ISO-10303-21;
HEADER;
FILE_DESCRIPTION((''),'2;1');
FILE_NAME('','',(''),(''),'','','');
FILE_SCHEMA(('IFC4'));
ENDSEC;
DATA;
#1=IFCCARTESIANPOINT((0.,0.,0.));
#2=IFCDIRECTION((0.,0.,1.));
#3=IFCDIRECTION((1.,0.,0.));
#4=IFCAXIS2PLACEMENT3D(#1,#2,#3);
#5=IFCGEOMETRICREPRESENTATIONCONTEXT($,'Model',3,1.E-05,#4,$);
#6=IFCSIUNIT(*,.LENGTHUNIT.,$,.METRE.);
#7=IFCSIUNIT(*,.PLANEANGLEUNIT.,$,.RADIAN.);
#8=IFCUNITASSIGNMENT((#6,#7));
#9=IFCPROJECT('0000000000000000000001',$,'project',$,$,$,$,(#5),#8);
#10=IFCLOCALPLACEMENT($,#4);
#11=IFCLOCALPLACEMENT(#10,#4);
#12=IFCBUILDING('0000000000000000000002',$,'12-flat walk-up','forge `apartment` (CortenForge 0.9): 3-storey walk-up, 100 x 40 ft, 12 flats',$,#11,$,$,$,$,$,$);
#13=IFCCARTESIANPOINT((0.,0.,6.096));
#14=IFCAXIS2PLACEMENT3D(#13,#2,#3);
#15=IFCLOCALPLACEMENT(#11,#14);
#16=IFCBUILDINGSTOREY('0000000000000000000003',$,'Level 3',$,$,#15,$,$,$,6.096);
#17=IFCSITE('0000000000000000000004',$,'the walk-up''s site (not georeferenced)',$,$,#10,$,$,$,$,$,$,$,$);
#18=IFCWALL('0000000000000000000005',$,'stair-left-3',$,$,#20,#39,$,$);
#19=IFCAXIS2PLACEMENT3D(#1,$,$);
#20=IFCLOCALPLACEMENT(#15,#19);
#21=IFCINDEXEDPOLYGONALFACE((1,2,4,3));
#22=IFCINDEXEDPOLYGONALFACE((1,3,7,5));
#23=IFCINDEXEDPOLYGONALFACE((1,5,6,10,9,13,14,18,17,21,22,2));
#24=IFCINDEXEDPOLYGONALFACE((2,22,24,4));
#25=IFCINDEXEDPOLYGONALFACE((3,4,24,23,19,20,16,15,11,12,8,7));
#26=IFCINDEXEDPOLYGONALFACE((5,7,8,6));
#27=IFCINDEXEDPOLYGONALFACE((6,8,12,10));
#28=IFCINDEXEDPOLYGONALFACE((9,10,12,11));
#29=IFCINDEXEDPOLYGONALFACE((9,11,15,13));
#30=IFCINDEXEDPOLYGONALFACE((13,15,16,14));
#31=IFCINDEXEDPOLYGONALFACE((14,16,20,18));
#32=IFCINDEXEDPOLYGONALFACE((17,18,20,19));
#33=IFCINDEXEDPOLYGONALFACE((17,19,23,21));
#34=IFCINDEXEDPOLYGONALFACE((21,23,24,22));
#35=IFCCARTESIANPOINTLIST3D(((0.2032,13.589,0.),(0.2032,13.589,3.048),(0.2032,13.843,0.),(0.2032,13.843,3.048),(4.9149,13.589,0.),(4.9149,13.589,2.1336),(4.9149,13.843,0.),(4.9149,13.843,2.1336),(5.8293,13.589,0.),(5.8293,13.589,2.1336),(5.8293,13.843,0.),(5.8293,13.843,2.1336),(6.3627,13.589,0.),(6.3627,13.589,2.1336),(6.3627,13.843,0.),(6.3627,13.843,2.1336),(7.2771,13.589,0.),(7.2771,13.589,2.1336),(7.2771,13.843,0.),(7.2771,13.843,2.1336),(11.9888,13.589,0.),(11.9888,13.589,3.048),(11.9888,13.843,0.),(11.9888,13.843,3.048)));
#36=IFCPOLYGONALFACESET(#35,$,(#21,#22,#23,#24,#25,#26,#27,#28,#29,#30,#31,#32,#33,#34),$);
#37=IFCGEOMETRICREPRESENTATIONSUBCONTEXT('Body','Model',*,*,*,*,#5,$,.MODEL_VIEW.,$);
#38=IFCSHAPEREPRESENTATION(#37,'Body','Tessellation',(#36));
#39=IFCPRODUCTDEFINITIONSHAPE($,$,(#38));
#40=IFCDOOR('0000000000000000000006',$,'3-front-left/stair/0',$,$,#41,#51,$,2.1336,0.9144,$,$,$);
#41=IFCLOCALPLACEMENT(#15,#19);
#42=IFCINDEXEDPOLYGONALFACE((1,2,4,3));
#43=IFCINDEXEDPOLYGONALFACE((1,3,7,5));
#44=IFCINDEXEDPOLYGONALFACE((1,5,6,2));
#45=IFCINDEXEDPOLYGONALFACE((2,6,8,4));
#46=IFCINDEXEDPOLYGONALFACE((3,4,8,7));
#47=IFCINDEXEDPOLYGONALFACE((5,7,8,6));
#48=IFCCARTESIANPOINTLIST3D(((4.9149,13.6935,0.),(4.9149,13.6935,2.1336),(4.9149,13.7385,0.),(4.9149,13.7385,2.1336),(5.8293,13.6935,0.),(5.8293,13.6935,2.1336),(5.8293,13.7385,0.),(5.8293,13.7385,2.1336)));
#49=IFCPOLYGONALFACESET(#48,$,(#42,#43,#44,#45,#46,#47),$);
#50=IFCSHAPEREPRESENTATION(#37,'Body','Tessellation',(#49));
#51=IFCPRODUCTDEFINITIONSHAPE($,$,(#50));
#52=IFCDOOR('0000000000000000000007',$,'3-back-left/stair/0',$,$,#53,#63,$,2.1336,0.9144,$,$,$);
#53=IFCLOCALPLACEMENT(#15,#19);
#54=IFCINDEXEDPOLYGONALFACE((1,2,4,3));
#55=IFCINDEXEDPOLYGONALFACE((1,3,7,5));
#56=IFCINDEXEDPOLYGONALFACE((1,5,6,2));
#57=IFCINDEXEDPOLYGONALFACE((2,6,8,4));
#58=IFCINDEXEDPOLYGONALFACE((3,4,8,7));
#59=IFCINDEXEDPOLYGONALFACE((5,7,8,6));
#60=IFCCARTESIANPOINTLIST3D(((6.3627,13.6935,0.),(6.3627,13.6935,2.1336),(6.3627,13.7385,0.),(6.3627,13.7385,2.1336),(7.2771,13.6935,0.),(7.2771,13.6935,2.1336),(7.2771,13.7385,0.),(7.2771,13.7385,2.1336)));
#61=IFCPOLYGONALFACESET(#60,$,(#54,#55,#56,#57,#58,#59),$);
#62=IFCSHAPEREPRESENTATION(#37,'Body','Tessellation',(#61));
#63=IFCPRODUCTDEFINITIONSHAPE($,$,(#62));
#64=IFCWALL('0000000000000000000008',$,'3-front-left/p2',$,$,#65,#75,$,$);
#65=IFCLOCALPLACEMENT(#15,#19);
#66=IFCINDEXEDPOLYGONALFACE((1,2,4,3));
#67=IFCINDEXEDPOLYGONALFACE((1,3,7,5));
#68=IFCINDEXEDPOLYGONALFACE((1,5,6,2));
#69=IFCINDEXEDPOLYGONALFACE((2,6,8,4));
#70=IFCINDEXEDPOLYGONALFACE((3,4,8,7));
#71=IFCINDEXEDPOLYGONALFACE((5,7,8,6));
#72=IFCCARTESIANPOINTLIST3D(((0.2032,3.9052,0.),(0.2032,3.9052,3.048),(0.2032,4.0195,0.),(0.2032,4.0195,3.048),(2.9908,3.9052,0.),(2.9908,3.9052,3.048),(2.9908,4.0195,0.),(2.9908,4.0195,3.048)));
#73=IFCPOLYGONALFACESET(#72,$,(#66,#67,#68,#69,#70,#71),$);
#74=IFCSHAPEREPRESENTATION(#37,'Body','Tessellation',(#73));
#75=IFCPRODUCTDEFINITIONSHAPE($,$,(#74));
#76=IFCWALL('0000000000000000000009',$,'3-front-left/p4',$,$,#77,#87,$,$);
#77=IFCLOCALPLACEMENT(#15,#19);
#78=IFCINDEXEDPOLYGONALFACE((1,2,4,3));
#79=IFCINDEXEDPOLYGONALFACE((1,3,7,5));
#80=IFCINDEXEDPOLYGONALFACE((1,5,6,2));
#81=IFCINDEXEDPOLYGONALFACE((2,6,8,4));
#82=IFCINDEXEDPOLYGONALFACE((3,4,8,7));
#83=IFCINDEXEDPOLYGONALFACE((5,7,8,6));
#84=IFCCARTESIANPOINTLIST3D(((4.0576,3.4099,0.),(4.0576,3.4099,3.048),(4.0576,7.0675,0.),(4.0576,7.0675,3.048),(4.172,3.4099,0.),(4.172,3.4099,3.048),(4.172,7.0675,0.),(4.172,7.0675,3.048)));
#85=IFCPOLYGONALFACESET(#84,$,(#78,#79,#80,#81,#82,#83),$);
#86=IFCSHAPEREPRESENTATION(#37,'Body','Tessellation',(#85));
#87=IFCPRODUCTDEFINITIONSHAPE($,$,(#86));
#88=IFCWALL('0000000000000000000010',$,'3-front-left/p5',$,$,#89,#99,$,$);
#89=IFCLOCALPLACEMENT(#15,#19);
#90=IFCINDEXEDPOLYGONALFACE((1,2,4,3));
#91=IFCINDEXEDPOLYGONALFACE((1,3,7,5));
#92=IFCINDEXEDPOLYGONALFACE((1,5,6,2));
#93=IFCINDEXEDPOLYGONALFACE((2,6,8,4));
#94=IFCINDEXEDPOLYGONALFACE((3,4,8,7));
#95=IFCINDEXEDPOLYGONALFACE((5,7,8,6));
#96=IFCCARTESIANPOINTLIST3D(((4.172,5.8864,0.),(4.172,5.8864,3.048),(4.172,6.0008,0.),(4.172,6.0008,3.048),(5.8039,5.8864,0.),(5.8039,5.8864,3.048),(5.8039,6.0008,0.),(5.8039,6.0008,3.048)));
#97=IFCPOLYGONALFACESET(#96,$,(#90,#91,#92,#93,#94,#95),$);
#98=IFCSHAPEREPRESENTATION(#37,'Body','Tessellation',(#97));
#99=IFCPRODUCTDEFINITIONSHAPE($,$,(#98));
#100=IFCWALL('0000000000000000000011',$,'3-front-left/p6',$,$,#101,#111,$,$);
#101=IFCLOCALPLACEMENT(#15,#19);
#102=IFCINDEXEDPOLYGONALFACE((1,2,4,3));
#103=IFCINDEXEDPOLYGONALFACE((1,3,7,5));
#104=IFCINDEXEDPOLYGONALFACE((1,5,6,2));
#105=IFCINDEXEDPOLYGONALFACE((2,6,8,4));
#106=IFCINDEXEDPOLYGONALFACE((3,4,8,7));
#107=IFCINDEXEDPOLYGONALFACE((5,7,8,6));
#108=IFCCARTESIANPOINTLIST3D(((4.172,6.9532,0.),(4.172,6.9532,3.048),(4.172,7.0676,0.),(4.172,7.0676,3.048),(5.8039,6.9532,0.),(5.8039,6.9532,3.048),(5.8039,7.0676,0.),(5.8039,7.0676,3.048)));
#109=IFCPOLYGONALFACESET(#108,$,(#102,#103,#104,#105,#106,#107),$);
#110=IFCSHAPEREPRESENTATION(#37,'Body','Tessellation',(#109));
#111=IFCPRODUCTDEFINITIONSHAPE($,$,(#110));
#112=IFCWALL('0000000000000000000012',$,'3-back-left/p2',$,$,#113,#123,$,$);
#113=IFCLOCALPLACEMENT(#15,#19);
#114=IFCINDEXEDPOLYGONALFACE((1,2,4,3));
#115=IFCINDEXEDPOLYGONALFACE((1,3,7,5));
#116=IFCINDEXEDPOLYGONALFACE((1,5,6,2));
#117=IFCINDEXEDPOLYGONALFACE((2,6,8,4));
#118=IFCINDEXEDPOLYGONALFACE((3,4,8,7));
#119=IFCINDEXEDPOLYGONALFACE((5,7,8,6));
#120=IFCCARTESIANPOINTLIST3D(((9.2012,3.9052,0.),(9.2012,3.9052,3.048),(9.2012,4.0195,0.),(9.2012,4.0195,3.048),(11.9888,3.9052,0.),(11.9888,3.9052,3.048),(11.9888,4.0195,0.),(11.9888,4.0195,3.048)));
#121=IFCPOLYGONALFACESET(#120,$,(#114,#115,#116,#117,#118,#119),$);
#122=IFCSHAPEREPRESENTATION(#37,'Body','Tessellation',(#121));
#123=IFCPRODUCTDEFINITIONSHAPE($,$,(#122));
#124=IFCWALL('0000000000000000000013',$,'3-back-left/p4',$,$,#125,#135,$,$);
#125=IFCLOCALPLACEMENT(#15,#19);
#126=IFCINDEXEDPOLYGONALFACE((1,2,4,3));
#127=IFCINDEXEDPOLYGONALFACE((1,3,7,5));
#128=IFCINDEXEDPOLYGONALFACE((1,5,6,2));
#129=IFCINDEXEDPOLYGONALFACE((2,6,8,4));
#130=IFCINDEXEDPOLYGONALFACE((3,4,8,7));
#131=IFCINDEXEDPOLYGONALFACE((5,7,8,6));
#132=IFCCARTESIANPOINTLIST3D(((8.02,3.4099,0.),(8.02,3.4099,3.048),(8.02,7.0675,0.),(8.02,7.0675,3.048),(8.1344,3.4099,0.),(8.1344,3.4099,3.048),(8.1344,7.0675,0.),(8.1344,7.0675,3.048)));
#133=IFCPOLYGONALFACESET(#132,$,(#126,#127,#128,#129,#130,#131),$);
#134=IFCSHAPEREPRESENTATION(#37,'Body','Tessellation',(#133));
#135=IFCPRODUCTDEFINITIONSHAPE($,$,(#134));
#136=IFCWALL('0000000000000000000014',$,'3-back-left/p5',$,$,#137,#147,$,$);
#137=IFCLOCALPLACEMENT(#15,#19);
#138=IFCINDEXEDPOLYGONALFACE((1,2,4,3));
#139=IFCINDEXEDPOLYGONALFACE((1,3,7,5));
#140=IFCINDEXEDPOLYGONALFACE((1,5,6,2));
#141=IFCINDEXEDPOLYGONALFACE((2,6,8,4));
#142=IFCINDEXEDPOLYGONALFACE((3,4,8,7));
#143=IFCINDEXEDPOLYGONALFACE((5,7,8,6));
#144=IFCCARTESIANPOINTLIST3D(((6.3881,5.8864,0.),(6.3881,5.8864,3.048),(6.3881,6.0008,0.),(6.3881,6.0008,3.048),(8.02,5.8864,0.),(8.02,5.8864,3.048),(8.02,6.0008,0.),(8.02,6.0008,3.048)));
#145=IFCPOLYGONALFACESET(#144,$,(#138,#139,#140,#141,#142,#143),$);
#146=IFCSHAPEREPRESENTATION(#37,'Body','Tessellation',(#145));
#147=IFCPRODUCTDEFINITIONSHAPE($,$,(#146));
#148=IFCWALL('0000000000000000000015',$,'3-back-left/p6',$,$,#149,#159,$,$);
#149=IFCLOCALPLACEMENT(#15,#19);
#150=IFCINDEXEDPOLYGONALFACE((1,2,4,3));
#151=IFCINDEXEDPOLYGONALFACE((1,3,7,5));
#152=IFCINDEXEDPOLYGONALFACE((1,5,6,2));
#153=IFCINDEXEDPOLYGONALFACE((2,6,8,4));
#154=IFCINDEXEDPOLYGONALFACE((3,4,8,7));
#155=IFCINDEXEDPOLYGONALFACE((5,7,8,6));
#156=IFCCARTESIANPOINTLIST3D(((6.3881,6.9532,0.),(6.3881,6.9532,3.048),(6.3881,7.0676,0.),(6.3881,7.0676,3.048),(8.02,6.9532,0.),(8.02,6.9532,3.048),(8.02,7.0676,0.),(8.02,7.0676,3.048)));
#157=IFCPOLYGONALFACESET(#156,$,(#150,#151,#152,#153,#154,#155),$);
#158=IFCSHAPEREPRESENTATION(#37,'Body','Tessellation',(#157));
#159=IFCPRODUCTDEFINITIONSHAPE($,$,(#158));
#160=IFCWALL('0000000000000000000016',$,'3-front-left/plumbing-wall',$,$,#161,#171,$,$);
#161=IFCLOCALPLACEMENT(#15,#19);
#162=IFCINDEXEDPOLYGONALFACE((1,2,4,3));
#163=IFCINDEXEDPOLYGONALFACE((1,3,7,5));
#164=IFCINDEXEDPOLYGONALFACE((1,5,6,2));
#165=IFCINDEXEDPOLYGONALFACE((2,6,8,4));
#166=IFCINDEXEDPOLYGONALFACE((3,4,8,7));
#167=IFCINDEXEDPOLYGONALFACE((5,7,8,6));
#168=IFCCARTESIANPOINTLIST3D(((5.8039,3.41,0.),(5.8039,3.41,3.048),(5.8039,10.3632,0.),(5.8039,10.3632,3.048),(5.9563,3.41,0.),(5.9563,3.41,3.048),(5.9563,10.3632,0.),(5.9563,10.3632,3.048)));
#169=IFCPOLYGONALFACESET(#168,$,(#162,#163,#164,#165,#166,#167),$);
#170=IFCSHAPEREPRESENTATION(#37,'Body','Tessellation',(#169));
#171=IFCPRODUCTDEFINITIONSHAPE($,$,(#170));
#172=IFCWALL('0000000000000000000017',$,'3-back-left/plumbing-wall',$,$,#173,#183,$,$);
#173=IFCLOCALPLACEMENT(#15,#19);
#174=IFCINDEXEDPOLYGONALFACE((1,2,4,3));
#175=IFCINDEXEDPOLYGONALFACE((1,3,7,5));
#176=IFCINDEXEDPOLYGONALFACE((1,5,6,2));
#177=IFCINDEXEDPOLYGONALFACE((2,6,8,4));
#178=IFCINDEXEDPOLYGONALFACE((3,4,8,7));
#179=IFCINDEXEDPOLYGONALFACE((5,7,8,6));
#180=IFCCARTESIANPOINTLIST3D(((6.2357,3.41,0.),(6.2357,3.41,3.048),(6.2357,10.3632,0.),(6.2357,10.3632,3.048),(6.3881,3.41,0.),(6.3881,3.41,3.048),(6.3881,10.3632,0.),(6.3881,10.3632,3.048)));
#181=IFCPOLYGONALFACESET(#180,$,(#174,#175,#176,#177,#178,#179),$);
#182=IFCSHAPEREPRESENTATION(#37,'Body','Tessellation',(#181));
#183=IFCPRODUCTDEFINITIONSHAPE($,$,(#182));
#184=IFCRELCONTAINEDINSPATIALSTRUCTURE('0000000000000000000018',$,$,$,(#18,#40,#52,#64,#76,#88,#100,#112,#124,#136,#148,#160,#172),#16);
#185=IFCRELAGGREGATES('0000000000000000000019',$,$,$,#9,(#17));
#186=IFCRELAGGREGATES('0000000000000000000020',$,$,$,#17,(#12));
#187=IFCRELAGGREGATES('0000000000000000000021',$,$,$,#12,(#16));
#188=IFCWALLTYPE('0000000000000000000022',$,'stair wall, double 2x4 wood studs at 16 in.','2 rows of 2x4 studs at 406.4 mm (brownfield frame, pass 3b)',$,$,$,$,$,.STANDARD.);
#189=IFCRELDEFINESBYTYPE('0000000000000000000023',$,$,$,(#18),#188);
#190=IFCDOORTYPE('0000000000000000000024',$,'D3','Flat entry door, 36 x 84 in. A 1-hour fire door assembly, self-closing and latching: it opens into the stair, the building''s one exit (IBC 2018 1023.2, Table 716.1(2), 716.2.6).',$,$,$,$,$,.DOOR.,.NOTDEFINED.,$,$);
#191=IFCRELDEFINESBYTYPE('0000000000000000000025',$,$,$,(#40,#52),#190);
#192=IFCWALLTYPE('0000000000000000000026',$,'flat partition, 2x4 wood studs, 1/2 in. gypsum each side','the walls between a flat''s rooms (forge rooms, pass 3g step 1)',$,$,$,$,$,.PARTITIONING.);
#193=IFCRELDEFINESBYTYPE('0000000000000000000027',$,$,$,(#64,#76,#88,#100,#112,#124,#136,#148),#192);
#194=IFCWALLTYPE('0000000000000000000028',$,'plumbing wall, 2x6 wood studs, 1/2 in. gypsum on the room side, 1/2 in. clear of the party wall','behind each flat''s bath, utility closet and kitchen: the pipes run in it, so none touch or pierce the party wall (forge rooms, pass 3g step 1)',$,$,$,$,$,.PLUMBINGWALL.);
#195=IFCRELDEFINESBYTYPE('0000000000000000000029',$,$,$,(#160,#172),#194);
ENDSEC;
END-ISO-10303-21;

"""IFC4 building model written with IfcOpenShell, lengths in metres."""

from ifc_helpers import new_model, si_unit, frame, frame_2d, origin, origin_with_axes, place, context, subcontext, project, spatial, rectangle, extrude, type_object, element, fill, save


model = new_model("IFC4")

# Units and contexts
model_context = context("Model", 3, precision=1e-05, world=origin_with_axes())
body_context = subcontext(model_context, "Body", "Model", "MODEL_VIEW")
ifc_project = project(units=[si_unit("LENGTHUNIT", "METRE"), si_unit("PLANEANGLEUNIT", "RADIAN")], contexts=[model_context])

# Site, building, storey
site_placement = place(None, origin_with_axes())
site = spatial("IfcSite", under=ifc_project, at=site_placement, Name="the walk-up's site (not georeferenced)")
building_placement = place(site_placement, origin_with_axes())
building = spatial("IfcBuilding", under=site, at=building_placement, Name="12-flat walk-up", Description="forge `apartment` (CortenForge 0.9): 3-storey walk-up, 100 x 40 ft, 12 flats")
storey_placement = place(building_placement, frame((0.0, 0.0, 6.096), z_axis=(0.0, 0.0, 1.0), x_axis=(1.0, 0.0, 0.0)))
storey = spatial("IfcBuildingStorey", under=building, at=storey_placement, Name="Level 3", Elevation=6.096)

# Wall, openings, doors
wall_type_1 = type_object("IfcWallType", Name="stair wall, double 2x4 wood studs at 16 in.", Description="2 rows of 2x4 studs at 406.4 mm (brownfield frame, pass 3b)", PredefinedType="STANDARD")
wall_1_placement = place(storey_placement, frame((0.2032, 13.589, 0.0), z_axis=(0.0, 0.0, 1.0), x_axis=(1.0, 0.0, 0.0)))
wall_1 = element("IfcWall", 1, at=wall_1_placement, inside=storey, type_object=wall_type_1, Name="stair-left-3", context=body_context, shape_type="SweptSolid", body=[
    extrude(rectangle(XDim=11.7856, YDim=0.254, at=frame_2d((5.8928, 0.127))), origin(), (0.0, 0.0, 1.0), 3.048),
])
opening_1_placement = place(wall_1_placement, frame((4.7117, 0.0, 0.0), z_axis=(0.0, 0.0, 1.0), x_axis=(1.0, 0.0, 0.0)))
opening_1 = element("IfcOpeningElement", 2, at=opening_1_placement, cuts=wall_1, PredefinedType="OPENING", context=body_context, shape_type="SweptSolid", body=[
    extrude(rectangle(XDim=0.9144, YDim=0.254, at=frame_2d((0.4572, 0.127))), origin(), (0.0, 0.0, 1.0), 2.1336),
])
opening_2_placement = place(wall_1_placement, frame((6.1595, 0.0, 0.0), z_axis=(0.0, 0.0, 1.0), x_axis=(1.0, 0.0, 0.0)))
opening_2 = element("IfcOpeningElement", 3, at=opening_2_placement, cuts=wall_1, PredefinedType="OPENING", context=body_context, shape_type="SweptSolid", body=[
    extrude(rectangle(XDim=0.9144, YDim=0.254, at=frame_2d((0.4572, 0.127))), origin(), (0.0, 0.0, 1.0), 2.1336),
])
door_type = type_object("IfcDoorType", Name="D3", Description="Flat entry door, 36 x 84 in. A 1-hour fire door assembly, self-closing and latching: it opens into the stair, the building's one exit (IBC 2018 1023.2, Table 716.1(2), 716.2.6).", OperationType="NOTDEFINED", PredefinedType="DOOR")
door_1_placement = place(opening_1_placement, frame((0.0, 0.1045, 0.0), z_axis=(0.0, 0.0, 1.0), x_axis=(1.0, 0.0, 0.0)))
door_1 = element("IfcDoor", 4, at=door_1_placement, inside=storey, type_object=door_type, Name="3-front-left/stair/0", OverallHeight=2.1336, OverallWidth=0.9144, context=body_context, shape_type="SweptSolid", body=[
    extrude(rectangle(XDim=0.9144, YDim=0.045, at=frame_2d((0.4572, 0.0225))), origin(), (0.0, 0.0, 1.0), 2.1336),
])
fill(opening_1, door_1)
door_2_placement = place(opening_2_placement, frame((0.0, 0.1045, 0.0), z_axis=(0.0, 0.0, 1.0), x_axis=(1.0, 0.0, 0.0)))
door_2 = element("IfcDoor", 5, at=door_2_placement, inside=storey, type_object=door_type, Name="3-back-left/stair/0", OverallHeight=2.1336, OverallWidth=0.9144, context=body_context, shape_type="SweptSolid", body=[
    extrude(rectangle(XDim=0.9144, YDim=0.045, at=frame_2d((0.4572, 0.0225))), origin(), (0.0, 0.0, 1.0), 2.1336),
])
fill(opening_2, door_2)

# Walls
wall_type_2 = type_object("IfcWallType", Name="flat partition, 2x4 wood studs, 1/2 in. gypsum each side", Description="the walls between a flat's rooms (forge rooms, pass 3g step 1)", PredefinedType="PARTITIONING")
wall_2_placement = place(storey_placement, frame((0.2032, 3.9052, 0.0), z_axis=(0.0, 0.0, 1.0), x_axis=(1.0, 0.0, 0.0)))
element("IfcWall", 6, at=wall_2_placement, inside=storey, type_object=wall_type_2, Name="3-front-left/p2", context=body_context, shape_type="SweptSolid", body=[
    extrude(rectangle(XDim=2.7877, YDim=0.1143, at=frame_2d((1.3938, 0.0571))), origin(), (0.0, 0.0, 1.0), 3.048),
])
wall_3_placement = place(storey_placement, frame((4.0576, 3.4099, 0.0), z_axis=(0.0, 0.0, 1.0), x_axis=(1.0, 0.0, 0.0)))
element("IfcWall", 7, at=wall_3_placement, inside=storey, type_object=wall_type_2, Name="3-front-left/p4", context=body_context, shape_type="SweptSolid", body=[
    extrude(rectangle(XDim=0.1143, YDim=3.6576, at=frame_2d((0.0572, 1.8288))), origin(), (0.0, 0.0, 1.0), 3.048),
])
for number, where, z_axis, x_axis, name in (
    (8, (4.1719, 5.8864, 0.0), (0.0, 0.0, 1.0), (1.0, 0.0, 0.0), "3-front-left/p5"),
    (9, (4.1719, 6.9532, 0.0), (0.0, 0.0, 1.0), (1.0, 0.0, 0.0), "3-front-left/p6"),
):
    element("IfcWall", number, at=place(storey_placement, frame(where, z_axis=z_axis, x_axis=x_axis)), inside=storey, type_object=wall_type_2, Name=name, context=body_context, shape_type="SweptSolid", body=[
        extrude(rectangle(XDim=1.6319, YDim=0.1143, at=frame_2d((0.816, 0.0572))), origin(), (0.0, 0.0, 1.0), 3.048),
    ])
wall_4_placement = place(storey_placement, frame((9.2012, 3.9052, 0.0), z_axis=(0.0, 0.0, 1.0), x_axis=(1.0, 0.0, 0.0)))
element("IfcWall", 10, at=wall_4_placement, inside=storey, type_object=wall_type_2, Name="3-back-left/p2", context=body_context, shape_type="SweptSolid", body=[
    extrude(rectangle(XDim=2.7876, YDim=0.1143, at=frame_2d((1.3938, 0.0571))), origin(), (0.0, 0.0, 1.0), 3.048),
])
wall_5_placement = place(storey_placement, frame((8.02, 3.4099, 0.0), z_axis=(0.0, 0.0, 1.0), x_axis=(1.0, 0.0, 0.0)))
element("IfcWall", 11, at=wall_5_placement, inside=storey, type_object=wall_type_2, Name="3-back-left/p4", context=body_context, shape_type="SweptSolid", body=[
    extrude(rectangle(XDim=0.1143, YDim=3.6576, at=frame_2d((0.0572, 1.8288))), origin(), (0.0, 0.0, 1.0), 3.048),
])
for number, where, z_axis, x_axis, name in (
    (12, (6.3881, 5.8864, 0.0), (0.0, 0.0, 1.0), (1.0, 0.0, 0.0), "3-back-left/p5"),
    (13, (6.3881, 6.9532, 0.0), (0.0, 0.0, 1.0), (1.0, 0.0, 0.0), "3-back-left/p6"),
):
    element("IfcWall", number, at=place(storey_placement, frame(where, z_axis=z_axis, x_axis=x_axis)), inside=storey, type_object=wall_type_2, Name=name, context=body_context, shape_type="SweptSolid", body=[
        extrude(rectangle(XDim=1.6319, YDim=0.1143, at=frame_2d((0.816, 0.0572))), origin(), (0.0, 0.0, 1.0), 3.048),
    ])
wall_type_3 = type_object("IfcWallType", Name="plumbing wall, 2x6 wood studs, 1/2 in. gypsum on the room side, 1/2 in. clear of the party wall", Description="behind each flat's bath, utility closet and kitchen: the pipes run in it, so none touch or pierce the party wall (forge rooms, pass 3g step 1)", PredefinedType="PLUMBINGWALL")
for number, where, z_axis, x_axis, name in (
    (14, (5.8039, 3.41, 0.0), (0.0, 0.0, 1.0), (1.0, 0.0, 0.0), "3-front-left/plumbing-wall"),
    (15, (6.2357, 3.41, 0.0), (0.0, 0.0, 1.0), (1.0, 0.0, 0.0), "3-back-left/plumbing-wall"),
):
    element("IfcWall", number, at=place(storey_placement, frame(where, z_axis=z_axis, x_axis=x_axis)), inside=storey, type_object=wall_type_3, Name=name, context=body_context, shape_type="SweptSolid", body=[
        extrude(rectangle(XDim=0.1524, YDim=6.9533, at=frame_2d((0.0762, 3.4766))), origin(), (0.0, 0.0, 1.0), 3.048),
    ])

save(model, "model.ifc")
